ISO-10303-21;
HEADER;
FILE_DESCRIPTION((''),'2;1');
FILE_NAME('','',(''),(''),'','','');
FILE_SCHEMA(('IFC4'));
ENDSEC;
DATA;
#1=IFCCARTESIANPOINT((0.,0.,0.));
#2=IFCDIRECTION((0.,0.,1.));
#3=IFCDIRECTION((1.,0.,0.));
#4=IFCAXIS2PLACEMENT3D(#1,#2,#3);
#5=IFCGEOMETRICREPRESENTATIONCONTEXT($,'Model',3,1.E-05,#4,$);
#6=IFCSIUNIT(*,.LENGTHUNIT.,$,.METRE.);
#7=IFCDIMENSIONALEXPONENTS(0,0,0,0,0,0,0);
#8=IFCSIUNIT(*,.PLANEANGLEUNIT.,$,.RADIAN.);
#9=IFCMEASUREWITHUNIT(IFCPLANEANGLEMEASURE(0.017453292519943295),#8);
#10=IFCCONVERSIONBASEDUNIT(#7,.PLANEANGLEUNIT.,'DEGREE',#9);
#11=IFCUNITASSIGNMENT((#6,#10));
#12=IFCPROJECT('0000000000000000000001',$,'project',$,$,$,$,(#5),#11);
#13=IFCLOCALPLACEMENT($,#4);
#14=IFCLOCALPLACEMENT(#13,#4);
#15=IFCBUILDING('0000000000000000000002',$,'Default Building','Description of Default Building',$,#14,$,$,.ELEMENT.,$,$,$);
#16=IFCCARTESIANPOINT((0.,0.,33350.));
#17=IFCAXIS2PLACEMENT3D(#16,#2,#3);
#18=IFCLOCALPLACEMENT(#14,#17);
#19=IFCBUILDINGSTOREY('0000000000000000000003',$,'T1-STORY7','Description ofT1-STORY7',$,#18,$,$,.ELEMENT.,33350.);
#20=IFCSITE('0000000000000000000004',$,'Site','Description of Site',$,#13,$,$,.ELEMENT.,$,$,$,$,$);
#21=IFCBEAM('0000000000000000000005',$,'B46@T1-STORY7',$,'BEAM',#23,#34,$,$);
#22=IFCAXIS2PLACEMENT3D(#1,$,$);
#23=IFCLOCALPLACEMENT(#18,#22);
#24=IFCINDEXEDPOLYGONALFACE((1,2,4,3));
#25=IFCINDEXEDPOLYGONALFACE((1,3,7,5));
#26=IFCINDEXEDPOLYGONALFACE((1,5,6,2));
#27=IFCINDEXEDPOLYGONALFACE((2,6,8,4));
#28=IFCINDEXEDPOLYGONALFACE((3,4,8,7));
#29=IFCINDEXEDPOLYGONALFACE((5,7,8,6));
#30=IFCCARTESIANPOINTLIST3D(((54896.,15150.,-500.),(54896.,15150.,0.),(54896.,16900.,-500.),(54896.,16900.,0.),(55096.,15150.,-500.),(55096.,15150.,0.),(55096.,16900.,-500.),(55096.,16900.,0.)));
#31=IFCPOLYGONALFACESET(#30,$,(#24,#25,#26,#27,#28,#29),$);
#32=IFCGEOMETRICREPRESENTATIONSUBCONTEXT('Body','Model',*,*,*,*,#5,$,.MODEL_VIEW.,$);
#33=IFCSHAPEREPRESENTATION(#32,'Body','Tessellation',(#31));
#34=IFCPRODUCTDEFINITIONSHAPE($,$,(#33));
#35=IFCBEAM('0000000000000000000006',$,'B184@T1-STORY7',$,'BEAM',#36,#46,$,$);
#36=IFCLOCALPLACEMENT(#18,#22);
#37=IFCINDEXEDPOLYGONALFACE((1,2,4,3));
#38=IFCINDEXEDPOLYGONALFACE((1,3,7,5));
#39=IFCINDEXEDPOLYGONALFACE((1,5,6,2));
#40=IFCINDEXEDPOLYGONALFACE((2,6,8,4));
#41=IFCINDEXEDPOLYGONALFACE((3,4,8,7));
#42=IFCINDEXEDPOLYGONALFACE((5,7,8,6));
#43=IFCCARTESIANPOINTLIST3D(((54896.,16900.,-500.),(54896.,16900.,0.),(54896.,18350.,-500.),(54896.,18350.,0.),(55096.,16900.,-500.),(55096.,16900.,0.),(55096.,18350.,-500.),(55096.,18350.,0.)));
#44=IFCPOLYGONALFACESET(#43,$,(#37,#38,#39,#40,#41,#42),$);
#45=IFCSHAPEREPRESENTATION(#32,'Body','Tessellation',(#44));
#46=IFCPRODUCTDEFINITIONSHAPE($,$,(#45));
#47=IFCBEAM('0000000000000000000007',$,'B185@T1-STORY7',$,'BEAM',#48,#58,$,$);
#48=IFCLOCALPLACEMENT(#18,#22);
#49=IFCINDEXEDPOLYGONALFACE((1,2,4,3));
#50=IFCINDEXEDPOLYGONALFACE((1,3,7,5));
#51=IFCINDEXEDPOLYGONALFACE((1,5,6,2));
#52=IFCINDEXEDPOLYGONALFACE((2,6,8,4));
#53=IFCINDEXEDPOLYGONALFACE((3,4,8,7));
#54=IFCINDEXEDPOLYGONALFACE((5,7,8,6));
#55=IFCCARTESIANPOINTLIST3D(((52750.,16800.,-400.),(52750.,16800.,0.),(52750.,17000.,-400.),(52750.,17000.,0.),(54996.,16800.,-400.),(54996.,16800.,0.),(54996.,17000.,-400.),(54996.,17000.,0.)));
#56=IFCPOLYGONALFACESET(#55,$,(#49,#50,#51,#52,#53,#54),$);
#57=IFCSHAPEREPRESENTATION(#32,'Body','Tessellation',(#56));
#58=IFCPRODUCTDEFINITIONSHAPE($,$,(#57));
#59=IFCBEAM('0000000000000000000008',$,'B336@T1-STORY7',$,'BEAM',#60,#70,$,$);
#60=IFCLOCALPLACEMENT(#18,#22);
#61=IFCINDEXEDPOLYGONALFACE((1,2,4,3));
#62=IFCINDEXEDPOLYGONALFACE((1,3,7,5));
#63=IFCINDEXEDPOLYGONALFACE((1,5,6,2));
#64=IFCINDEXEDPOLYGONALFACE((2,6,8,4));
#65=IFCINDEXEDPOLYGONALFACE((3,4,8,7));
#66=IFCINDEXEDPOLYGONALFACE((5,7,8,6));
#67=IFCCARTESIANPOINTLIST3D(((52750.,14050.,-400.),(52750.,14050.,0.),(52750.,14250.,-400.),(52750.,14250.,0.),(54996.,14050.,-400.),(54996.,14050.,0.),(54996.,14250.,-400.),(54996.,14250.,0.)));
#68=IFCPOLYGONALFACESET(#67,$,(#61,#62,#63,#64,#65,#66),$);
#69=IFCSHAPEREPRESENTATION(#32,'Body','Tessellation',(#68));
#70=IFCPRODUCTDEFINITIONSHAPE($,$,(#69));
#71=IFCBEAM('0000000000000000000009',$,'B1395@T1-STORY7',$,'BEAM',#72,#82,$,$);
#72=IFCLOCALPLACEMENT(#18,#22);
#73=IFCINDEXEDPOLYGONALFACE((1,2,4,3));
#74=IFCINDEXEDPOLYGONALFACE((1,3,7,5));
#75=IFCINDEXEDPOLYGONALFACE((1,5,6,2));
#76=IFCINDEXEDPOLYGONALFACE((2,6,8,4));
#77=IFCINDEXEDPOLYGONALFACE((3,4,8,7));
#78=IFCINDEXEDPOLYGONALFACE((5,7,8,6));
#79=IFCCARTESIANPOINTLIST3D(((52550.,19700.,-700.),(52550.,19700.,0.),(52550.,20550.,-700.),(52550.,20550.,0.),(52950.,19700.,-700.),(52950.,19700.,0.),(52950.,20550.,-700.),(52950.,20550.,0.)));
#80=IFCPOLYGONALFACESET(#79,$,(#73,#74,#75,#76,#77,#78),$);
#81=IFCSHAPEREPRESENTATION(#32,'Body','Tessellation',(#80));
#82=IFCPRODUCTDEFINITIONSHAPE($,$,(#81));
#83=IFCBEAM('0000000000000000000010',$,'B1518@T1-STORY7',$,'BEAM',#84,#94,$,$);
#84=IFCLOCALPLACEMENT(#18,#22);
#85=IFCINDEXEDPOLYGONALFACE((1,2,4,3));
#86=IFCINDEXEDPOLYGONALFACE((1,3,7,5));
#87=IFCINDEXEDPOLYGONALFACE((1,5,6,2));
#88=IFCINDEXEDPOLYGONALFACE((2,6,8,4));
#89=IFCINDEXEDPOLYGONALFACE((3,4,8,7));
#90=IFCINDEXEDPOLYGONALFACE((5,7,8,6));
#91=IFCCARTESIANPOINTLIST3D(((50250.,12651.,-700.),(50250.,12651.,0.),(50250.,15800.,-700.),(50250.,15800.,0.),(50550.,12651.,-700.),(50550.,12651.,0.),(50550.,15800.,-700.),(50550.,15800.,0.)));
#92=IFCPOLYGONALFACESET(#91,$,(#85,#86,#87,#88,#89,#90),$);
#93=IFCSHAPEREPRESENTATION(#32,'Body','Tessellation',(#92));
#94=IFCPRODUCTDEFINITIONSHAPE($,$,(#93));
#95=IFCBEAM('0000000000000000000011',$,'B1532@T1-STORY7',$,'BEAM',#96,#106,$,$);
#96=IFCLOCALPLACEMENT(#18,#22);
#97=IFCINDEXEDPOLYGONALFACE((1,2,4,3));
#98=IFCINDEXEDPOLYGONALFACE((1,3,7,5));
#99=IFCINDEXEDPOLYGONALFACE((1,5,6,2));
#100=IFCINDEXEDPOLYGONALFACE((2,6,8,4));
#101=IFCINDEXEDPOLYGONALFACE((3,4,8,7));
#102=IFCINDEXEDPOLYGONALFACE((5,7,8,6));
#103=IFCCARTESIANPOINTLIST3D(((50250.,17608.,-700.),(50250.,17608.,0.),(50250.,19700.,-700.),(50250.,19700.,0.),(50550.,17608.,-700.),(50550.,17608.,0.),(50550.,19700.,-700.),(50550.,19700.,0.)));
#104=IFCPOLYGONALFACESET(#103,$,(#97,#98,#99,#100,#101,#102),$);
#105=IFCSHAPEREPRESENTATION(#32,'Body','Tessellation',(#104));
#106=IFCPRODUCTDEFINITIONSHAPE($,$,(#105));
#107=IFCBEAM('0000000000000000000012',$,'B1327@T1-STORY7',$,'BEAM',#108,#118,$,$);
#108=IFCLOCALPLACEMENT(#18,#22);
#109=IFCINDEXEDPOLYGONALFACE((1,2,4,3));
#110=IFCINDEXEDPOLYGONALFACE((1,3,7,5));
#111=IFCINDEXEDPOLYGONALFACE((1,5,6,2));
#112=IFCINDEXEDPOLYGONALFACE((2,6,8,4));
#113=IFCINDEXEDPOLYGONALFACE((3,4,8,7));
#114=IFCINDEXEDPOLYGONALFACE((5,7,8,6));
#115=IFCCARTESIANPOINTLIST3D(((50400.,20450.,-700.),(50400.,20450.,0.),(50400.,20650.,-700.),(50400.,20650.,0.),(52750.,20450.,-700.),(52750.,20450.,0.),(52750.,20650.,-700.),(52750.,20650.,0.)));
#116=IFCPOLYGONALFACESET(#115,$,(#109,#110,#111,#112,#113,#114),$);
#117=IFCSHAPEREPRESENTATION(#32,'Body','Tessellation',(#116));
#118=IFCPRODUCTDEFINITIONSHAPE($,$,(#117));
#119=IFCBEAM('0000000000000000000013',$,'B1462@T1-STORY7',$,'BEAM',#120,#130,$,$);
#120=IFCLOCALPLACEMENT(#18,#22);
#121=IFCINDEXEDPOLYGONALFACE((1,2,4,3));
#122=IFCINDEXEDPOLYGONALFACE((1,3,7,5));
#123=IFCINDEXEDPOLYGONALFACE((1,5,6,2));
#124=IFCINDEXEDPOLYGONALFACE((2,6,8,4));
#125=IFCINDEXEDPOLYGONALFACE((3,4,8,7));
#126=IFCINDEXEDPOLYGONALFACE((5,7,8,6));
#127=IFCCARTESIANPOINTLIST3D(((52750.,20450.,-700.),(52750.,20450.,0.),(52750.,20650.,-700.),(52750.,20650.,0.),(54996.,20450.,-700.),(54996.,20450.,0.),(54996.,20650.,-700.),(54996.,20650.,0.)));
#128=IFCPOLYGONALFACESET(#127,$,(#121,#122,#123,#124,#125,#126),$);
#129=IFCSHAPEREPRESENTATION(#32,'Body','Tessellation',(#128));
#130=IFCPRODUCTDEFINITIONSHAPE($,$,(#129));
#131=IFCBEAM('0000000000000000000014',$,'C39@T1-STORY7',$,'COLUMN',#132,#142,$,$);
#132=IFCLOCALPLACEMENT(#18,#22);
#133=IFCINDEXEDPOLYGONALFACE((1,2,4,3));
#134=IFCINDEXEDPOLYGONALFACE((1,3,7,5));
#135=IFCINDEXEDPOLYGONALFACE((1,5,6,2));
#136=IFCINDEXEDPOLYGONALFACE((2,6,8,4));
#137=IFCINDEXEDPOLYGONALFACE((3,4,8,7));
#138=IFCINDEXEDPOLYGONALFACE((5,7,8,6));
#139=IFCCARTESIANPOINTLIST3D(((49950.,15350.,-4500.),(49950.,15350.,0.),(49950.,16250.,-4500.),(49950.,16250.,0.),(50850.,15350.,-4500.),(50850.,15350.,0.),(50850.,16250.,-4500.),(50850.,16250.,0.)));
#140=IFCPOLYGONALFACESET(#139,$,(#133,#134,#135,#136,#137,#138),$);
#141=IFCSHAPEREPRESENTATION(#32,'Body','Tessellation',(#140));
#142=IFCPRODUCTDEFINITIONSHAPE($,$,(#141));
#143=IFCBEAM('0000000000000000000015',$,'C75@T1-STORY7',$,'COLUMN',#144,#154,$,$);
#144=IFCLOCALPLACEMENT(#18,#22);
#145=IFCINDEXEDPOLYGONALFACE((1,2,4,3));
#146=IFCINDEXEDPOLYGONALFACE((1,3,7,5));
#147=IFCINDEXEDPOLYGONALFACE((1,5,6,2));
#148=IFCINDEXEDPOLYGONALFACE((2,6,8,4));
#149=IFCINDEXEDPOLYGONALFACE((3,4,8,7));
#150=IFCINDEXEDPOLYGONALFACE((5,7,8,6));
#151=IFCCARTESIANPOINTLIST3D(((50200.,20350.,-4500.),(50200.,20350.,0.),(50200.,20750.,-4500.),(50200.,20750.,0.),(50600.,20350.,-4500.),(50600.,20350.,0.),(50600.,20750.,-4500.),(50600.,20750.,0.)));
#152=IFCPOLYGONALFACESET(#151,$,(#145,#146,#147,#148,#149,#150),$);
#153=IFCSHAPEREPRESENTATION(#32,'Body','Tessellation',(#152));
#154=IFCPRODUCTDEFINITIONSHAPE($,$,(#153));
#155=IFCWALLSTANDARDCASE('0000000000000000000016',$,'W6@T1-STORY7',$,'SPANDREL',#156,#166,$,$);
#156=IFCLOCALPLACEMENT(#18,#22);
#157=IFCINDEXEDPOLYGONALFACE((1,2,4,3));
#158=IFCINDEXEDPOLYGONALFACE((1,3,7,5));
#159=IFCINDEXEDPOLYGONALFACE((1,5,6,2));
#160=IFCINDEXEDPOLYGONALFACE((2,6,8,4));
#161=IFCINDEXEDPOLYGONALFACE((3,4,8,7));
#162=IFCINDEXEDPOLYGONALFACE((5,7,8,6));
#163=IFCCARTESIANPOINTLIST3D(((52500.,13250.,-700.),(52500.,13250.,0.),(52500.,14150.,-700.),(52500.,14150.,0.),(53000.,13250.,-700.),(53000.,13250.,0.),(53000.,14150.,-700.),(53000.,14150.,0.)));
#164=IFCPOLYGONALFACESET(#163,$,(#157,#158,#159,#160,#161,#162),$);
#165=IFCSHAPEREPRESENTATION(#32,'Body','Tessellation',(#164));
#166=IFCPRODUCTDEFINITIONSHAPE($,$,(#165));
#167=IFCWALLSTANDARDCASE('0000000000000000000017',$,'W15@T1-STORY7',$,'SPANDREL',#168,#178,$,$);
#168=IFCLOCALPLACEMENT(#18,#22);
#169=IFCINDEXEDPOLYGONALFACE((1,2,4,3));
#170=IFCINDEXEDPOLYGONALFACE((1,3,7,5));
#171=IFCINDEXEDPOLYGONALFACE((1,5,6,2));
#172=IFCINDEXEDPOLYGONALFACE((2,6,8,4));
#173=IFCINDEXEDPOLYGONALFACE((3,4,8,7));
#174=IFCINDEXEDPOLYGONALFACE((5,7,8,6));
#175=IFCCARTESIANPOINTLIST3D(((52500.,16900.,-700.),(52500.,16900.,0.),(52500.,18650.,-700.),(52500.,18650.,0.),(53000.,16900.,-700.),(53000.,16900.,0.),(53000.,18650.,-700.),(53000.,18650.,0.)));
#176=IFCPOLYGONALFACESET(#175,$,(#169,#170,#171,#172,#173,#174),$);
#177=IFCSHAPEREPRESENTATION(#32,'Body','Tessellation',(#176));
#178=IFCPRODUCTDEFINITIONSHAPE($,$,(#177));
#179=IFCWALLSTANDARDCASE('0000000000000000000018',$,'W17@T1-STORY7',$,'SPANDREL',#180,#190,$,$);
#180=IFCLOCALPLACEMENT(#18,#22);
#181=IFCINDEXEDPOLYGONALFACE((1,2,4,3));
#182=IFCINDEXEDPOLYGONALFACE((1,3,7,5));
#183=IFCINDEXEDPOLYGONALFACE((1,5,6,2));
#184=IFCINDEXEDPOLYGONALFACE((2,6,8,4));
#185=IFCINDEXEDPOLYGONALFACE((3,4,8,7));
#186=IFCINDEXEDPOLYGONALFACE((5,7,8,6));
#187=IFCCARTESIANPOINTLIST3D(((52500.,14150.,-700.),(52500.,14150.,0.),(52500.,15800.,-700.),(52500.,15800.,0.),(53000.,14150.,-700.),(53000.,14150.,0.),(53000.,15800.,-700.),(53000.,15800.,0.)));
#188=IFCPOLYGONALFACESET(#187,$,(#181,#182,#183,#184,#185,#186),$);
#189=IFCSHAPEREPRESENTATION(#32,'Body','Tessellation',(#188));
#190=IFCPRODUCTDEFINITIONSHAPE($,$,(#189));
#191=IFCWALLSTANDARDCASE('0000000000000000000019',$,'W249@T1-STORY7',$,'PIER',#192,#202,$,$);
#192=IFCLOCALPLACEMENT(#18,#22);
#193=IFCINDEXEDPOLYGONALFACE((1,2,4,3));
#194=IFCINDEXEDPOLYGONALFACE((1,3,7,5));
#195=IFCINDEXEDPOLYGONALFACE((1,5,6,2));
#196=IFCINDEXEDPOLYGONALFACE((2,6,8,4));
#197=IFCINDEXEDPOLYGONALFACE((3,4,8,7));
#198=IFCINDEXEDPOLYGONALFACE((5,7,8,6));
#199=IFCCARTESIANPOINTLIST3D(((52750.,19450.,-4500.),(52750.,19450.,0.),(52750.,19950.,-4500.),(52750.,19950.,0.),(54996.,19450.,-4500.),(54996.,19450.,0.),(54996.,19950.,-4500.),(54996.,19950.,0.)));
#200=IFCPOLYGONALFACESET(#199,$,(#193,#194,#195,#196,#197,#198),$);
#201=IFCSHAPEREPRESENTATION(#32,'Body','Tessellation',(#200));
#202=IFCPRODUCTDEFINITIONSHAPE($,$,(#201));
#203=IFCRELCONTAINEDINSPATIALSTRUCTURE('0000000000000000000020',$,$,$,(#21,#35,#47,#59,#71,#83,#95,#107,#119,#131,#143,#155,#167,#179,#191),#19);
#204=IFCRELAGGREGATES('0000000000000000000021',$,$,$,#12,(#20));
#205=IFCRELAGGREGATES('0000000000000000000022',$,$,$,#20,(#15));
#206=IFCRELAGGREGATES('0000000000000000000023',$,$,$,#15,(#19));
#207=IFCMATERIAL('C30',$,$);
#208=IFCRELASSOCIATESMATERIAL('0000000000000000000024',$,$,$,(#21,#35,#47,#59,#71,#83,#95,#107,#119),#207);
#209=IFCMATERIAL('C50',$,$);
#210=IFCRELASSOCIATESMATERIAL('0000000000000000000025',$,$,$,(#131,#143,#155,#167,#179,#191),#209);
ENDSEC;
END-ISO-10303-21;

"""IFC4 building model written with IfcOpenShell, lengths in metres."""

from ifc_helpers import new_model, entity, si_unit, converted_unit, frame, origin_with_axes, place, context, subcontext, project, spatial, indexed_curve, rectangle, outline, extrude, material, element, save


model = new_model("IFC4")

# Units and contexts
model_context = context("Model", 3, precision=1e-05, world=origin_with_axes())
body_context = subcontext(model_context, "Body", "Model", "MODEL_VIEW")
ifc_project = project(units=[si_unit("LENGTHUNIT", "METRE"), converted_unit("PLANEANGLEUNIT", "DEGREE", entity("IfcPlaneAngleMeasure", 0.017453292519943295), si_unit("PLANEANGLEUNIT", "RADIAN"), dimensions=[0, 0, 0, 0, 0, 0, 0])], contexts=[model_context])

# Site, building, storey
site_placement = place(None, origin_with_axes())
site = spatial("IfcSite", under=ifc_project, at=site_placement, Name="Site", Description="Description of Site", CompositionType="ELEMENT")
building_placement = place(site_placement, origin_with_axes())
building = spatial("IfcBuilding", under=site, at=building_placement, Name="Default Building", Description="Description of Default Building", CompositionType="ELEMENT")
storey_placement = place(building_placement, frame((0.0, 0.0, 33350.0), z_axis=(0.0, 0.0, 1.0), x_axis=(1.0, 0.0, 0.0)))
storey = spatial("IfcBuildingStorey", under=building, at=storey_placement, Name="T1-STORY7", Description="Description ofT1-STORY7", CompositionType="ELEMENT", Elevation=33350.0)

# Beams
ifc_material_1 = material(Name="C30")
beam_1_placement = place(storey_placement, frame((54996.0, 15150.0, -250.0), z_axis=(0.0, 1.0, 0.0), x_axis=(-1.0, 0.0, 0.0)))
element("IfcBeam", 1, at=beam_1_placement, inside=storey, material=ifc_material_1, Name="B46@T1-STORY7", ObjectType="BEAM", context=body_context, shape_type="SweptSolid", body=[
    extrude(rectangle(XDim=200.0, YDim=500.0), origin_with_axes(), (0.0, 0.0, 1.0), 1750.0),
])
beam_2_placement = place(storey_placement, frame((54996.0, 16900.0, -250.0), z_axis=(0.0, 1.0, 0.0), x_axis=(-1.0, 0.0, 0.0)))
element("IfcBeam", 2, at=beam_2_placement, inside=storey, material=ifc_material_1, Name="B184@T1-STORY7", ObjectType="BEAM", context=body_context, shape_type="SweptSolid", body=[
    extrude(rectangle(XDim=200.0, YDim=500.0), origin_with_axes(), (0.0, 0.0, 1.0), 1450.0),
])
for number, where, z_axis, x_axis, name in (
    (3, (52750.0, 16900.0, -200.0), (1.0, 0.0, 0.0), (0.0, 1.0, 0.0), "B185@T1-STORY7"),
    (4, (52750.0, 14150.0, -200.0), (1.0, 0.0, 0.0), (0.0, 1.0, 0.0), "B336@T1-STORY7"),
):
    element("IfcBeam", number, at=place(storey_placement, frame(where, z_axis=z_axis, x_axis=x_axis)), inside=storey, material=ifc_material_1, Name=name, ObjectType="BEAM", context=body_context, shape_type="SweptSolid", body=[
        extrude(rectangle(XDim=200.0, YDim=400.0), origin_with_axes(), (0.0, 0.0, 1.0), 2246.0),
    ])
beam_3_placement = place(storey_placement, frame((52750.0, 19700.0, -350.0), z_axis=(0.0, 1.0, 0.0), x_axis=(-1.0, 0.0, 0.0)))
element("IfcBeam", 5, at=beam_3_placement, inside=storey, material=ifc_material_1, Name="B1395@T1-STORY7", ObjectType="BEAM", context=body_context, shape_type="SweptSolid", body=[
    extrude(rectangle(XDim=400.0, YDim=700.0), origin_with_axes(), (0.0, 0.0, 1.0), 850.0),
])
beam_4_placement = place(storey_placement, frame((50400.0, 12651.0, -350.0), z_axis=(0.0, 1.0, 0.0), x_axis=(-1.0, 0.0, 0.0)))
element("IfcBeam", 6, at=beam_4_placement, inside=storey, material=ifc_material_1, Name="B1518@T1-STORY7", ObjectType="BEAM", context=body_context, shape_type="SweptSolid", body=[
    extrude(rectangle(XDim=300.0, YDim=700.0), origin_with_axes(), (0.0, 0.0, 1.0), 3149.0),
])
beam_5_placement = place(storey_placement, frame((50400.0, 17608.0, -350.0), z_axis=(0.0, 1.0, 0.0), x_axis=(-1.0, 0.0, 0.0)))
element("IfcBeam", 7, at=beam_5_placement, inside=storey, material=ifc_material_1, Name="B1532@T1-STORY7", ObjectType="BEAM", context=body_context, shape_type="SweptSolid", body=[
    extrude(rectangle(XDim=300.0, YDim=700.0), origin_with_axes(), (0.0, 0.0, 1.0), 2092.0),
])
beam_6_placement = place(storey_placement, frame((50400.0, 20550.0, -350.0), z_axis=(1.0, 0.0, 0.0), x_axis=(0.0, 1.0, 0.0)))
element("IfcBeam", 8, at=beam_6_placement, inside=storey, material=ifc_material_1, Name="B1327@T1-STORY7", ObjectType="BEAM", context=body_context, shape_type="SweptSolid", body=[
    extrude(rectangle(XDim=200.0, YDim=700.0), origin_with_axes(), (0.0, 0.0, 1.0), 2350.0),
])
beam_7_placement = place(storey_placement, frame((52750.0, 20550.0, -350.0), z_axis=(1.0, 0.0, 0.0), x_axis=(0.0, 1.0, 0.0)))
element("IfcBeam", 9, at=beam_7_placement, inside=storey, material=ifc_material_1, Name="B1462@T1-STORY7", ObjectType="BEAM", context=body_context, shape_type="SweptSolid", body=[
    extrude(rectangle(XDim=200.0, YDim=700.0), origin_with_axes(), (0.0, 0.0, 1.0), 2246.0),
])
ifc_material_2 = material(Name="C50")
beam_8_placement = place(storey_placement, frame((50400.0, 15800.0, -4500.0), z_axis=(0.0, 0.0, 1.0), x_axis=(-1.0, 0.0, 0.0)))
element("IfcBeam", 10, at=beam_8_placement, inside=storey, material=ifc_material_2, Name="C39@T1-STORY7", ObjectType="COLUMN", context=body_context, shape_type="SweptSolid", body=[
    extrude(rectangle(XDim=900.0, YDim=900.0), origin_with_axes(), (0.0, 0.0, 1.0), 4500.0),
])
beam_9_placement = place(storey_placement, frame((50400.0, 20550.0, -4500.0), z_axis=(0.0, 0.0, 1.0), x_axis=(-1.0, 0.0, 0.0)))
element("IfcBeam", 11, at=beam_9_placement, inside=storey, material=ifc_material_2, Name="C75@T1-STORY7", ObjectType="COLUMN", context=body_context, shape_type="SweptSolid", body=[
    extrude(rectangle(XDim=400.0, YDim=400.0), origin_with_axes(), (0.0, 0.0, 1.0), 4500.0),
])

# Walls
wall_1_placement = place(storey_placement, frame((52750.0, 13250.0, -700.0), z_axis=(0.0, 0.0, 1.0), x_axis=(0.0, 1.0, 0.0)))
element("IfcWallStandardCase", 12, at=wall_1_placement, inside=storey, material=ifc_material_2, Name="W6@T1-STORY7", ObjectType="SPANDREL", context=body_context, shape_type="SweptSolid", body=[
    extrude(outline(indexed_curve([(0.0, -250.0), (0.0, 250.0), (900.0, 250.0), (900.0, -250.0), (0.0, -250.0)], self_intersect=False)), origin_with_axes(), (0.0, 0.0, 1.0), 700.0),
])
wall_2_placement = place(storey_placement, frame((52750.0, 16900.0, -700.0), z_axis=(0.0, 0.0, 1.0), x_axis=(0.0, 1.0, 0.0)))
element("IfcWallStandardCase", 13, at=wall_2_placement, inside=storey, material=ifc_material_2, Name="W15@T1-STORY7", ObjectType="SPANDREL", context=body_context, shape_type="SweptSolid", body=[
    extrude(outline(indexed_curve([(0.0, -250.0), (0.0, 250.0), (1750.0, 250.0), (1750.0, -250.0), (0.0, -250.0)], self_intersect=False)), origin_with_axes(), (0.0, 0.0, 1.0), 700.0),
])
wall_3_placement = place(storey_placement, frame((52750.0, 14150.0, -700.0), z_axis=(0.0, 0.0, 1.0), x_axis=(0.0, 1.0, 0.0)))
element("IfcWallStandardCase", 14, at=wall_3_placement, inside=storey, material=ifc_material_2, Name="W17@T1-STORY7", ObjectType="SPANDREL", context=body_context, shape_type="SweptSolid", body=[
    extrude(outline(indexed_curve([(0.0, -250.0), (0.0, 250.0), (1650.0, 250.0), (1650.0, -250.0), (0.0, -250.0)], self_intersect=False)), origin_with_axes(), (0.0, 0.0, 1.0), 700.0),
])
wall_4_placement = place(storey_placement, frame((52750.0, 19700.0, -4500.0), z_axis=(0.0, 0.0, 1.0), x_axis=(1.0, 0.0, 0.0)))
element("IfcWallStandardCase", 15, at=wall_4_placement, inside=storey, material=ifc_material_2, Name="W249@T1-STORY7", ObjectType="PIER", context=body_context, shape_type="SweptSolid", body=[
    extrude(outline(indexed_curve([(0.0, -250.0), (0.0, 250.0), (2246.0, 250.0), (2246.0, -250.0), (0.0, -250.0)], self_intersect=False)), origin_with_axes(), (0.0, 0.0, 1.0), 4500.0),
])

save(model, "model.ifc")
